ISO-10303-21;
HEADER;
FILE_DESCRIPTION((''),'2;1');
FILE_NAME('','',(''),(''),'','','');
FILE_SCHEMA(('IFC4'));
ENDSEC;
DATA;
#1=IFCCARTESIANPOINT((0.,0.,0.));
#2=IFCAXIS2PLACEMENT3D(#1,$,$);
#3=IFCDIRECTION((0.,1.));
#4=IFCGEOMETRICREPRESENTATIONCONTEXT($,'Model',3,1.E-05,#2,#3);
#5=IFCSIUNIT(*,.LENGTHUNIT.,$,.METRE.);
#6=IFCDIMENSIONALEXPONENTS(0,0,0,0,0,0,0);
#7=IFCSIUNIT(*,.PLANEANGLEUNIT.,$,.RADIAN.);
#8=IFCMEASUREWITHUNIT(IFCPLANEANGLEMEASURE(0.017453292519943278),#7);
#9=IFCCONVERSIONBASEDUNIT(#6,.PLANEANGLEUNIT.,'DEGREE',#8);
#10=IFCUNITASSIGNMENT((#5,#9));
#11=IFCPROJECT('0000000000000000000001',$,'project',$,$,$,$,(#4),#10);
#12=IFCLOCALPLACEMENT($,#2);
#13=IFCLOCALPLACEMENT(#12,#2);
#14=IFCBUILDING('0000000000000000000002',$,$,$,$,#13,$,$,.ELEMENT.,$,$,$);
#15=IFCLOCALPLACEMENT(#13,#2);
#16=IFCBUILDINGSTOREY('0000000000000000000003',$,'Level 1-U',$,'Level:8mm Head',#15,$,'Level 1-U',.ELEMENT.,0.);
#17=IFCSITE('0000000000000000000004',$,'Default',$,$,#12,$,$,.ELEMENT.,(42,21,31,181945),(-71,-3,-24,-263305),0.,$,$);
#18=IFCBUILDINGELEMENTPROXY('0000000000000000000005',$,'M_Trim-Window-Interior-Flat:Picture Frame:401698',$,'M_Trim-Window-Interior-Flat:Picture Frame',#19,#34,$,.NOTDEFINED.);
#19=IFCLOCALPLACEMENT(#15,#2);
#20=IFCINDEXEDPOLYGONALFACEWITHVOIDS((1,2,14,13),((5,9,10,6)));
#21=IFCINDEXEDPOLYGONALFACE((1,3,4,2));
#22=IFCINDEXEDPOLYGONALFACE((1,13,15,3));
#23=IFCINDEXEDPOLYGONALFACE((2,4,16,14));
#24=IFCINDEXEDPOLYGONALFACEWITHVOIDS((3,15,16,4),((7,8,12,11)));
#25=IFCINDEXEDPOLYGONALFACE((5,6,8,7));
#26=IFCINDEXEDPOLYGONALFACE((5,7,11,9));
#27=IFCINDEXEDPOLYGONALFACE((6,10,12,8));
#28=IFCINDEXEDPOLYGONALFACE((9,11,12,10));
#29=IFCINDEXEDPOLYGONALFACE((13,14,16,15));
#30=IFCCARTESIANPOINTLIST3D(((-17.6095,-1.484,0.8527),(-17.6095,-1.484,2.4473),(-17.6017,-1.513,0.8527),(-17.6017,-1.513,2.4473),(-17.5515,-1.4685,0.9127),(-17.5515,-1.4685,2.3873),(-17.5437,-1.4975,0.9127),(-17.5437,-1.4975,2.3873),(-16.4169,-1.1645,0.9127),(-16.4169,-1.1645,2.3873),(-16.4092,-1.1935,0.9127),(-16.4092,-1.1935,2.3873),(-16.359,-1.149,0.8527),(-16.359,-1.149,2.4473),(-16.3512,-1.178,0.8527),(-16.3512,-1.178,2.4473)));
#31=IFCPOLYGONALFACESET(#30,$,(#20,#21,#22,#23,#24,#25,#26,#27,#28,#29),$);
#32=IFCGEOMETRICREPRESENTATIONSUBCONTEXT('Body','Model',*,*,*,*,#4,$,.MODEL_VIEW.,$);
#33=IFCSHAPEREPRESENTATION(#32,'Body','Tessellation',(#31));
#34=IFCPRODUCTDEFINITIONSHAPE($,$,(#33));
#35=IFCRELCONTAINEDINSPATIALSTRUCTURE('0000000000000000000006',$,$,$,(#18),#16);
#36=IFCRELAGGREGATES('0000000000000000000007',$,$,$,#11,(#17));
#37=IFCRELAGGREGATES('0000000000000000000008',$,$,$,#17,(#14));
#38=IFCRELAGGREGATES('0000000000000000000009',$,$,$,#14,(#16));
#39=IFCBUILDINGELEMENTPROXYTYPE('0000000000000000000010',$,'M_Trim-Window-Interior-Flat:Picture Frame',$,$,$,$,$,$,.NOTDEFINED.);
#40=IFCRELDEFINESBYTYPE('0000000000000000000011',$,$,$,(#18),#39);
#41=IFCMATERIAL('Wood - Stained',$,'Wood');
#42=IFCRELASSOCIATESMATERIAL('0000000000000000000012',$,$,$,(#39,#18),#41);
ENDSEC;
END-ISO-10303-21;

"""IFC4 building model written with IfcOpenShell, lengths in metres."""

from ifc_helpers import new_model, entity, si_unit, converted_unit, direction, frame, origin, place, context, subcontext, project, spatial, indexed_curve, outline, extrude, source, transform, mapped, material, type_object, type_shapes, element, save


model = new_model("IFC4")

# Units and contexts
model_context = context("Model", 3, precision=1e-05, world=origin(), true_north=direction((0.0, 1.0)))
body_context = subcontext(model_context, "Body", "Model", "MODEL_VIEW")
ifc_project = project(units=[si_unit("LENGTHUNIT", "METRE"), converted_unit("PLANEANGLEUNIT", "DEGREE", entity("IfcPlaneAngleMeasure", 0.017453292519943278), si_unit("PLANEANGLEUNIT", "RADIAN"), dimensions=[0, 0, 0, 0, 0, 0, 0])], contexts=[model_context])

# Site, building, storey
site_placement = place(None, origin())
site = spatial("IfcSite", under=ifc_project, at=site_placement, Name="Default", CompositionType="ELEMENT", RefLatitude=(42, 21, 31, 181945), RefLongitude=(-71, -3, -24, -263305), RefElevation=0.0)
building_placement = place(site_placement, origin())
building = spatial("IfcBuilding", under=site, at=building_placement, CompositionType="ELEMENT")
storey_placement = place(building_placement, origin())
storey = spatial("IfcBuildingStorey", under=building, at=storey_placement, Name="Level 1-U", ObjectType="Level:8mm Head", LongName="Level 1-U", CompositionType="ELEMENT", Elevation=0.0)

# Building element proxy
ifc_material_1 = material(Name="Wood - Stained", Category="Wood")
building_element_proxy_type_1 = type_object("IfcBuildingElementProxyType", Name="M_Trim-Window-Interior-Flat:Picture Frame", PredefinedType="NOTDEFINED", material=ifc_material_1)
shared_shape_1 = source(origin(), body_context, "Body", "SweptSolid", [
    extrude(outline(indexed_curve([(-0.6473, -0.7973), (0.6473, -0.7973), (0.6473, 0.7973), (-0.6473, 0.7973), (-0.6473, -0.7973)], self_intersect=False), holes=[indexed_curve([(-0.5873, -0.7373), (-0.5873, 0.7373), (0.5873, 0.7373), (0.5873, -0.7373), (-0.5873, -0.7373)], self_intersect=False)]), frame((0.0, -0.75, 0.0), z_axis=(0.0, 0.0, 1.0), x_axis=(-1.0, 0.0, 0.0)), (0.0, 0.0, 1.0), 0.03),
])
type_shapes(building_element_proxy_type_1, [shared_shape_1])
for number, where, z_axis, x_axis, name in (
    (1, (-16.9765, -1.3455, 2.4), (-0.258819, 0.965926, 0.0), (-0.965926, -0.258819, 0.0), "M_Trim-Window-Interior-Flat:Picture Frame:401698"),
):
    element("IfcBuildingElementProxy", number, at=place(storey_placement, frame(where, z_axis=z_axis, x_axis=x_axis)), inside=storey, type_object=building_element_proxy_type_1, material=ifc_material_1, Name=name, ObjectType="M_Trim-Window-Interior-Flat:Picture Frame", PredefinedType="NOTDEFINED", context=body_context, shape_type="MappedRepresentation", body=[
        mapped(shared_shape_1, transform((0.0, 0.0, 0.0), scale=1.0)),
    ])

save(model, "model.ifc")
